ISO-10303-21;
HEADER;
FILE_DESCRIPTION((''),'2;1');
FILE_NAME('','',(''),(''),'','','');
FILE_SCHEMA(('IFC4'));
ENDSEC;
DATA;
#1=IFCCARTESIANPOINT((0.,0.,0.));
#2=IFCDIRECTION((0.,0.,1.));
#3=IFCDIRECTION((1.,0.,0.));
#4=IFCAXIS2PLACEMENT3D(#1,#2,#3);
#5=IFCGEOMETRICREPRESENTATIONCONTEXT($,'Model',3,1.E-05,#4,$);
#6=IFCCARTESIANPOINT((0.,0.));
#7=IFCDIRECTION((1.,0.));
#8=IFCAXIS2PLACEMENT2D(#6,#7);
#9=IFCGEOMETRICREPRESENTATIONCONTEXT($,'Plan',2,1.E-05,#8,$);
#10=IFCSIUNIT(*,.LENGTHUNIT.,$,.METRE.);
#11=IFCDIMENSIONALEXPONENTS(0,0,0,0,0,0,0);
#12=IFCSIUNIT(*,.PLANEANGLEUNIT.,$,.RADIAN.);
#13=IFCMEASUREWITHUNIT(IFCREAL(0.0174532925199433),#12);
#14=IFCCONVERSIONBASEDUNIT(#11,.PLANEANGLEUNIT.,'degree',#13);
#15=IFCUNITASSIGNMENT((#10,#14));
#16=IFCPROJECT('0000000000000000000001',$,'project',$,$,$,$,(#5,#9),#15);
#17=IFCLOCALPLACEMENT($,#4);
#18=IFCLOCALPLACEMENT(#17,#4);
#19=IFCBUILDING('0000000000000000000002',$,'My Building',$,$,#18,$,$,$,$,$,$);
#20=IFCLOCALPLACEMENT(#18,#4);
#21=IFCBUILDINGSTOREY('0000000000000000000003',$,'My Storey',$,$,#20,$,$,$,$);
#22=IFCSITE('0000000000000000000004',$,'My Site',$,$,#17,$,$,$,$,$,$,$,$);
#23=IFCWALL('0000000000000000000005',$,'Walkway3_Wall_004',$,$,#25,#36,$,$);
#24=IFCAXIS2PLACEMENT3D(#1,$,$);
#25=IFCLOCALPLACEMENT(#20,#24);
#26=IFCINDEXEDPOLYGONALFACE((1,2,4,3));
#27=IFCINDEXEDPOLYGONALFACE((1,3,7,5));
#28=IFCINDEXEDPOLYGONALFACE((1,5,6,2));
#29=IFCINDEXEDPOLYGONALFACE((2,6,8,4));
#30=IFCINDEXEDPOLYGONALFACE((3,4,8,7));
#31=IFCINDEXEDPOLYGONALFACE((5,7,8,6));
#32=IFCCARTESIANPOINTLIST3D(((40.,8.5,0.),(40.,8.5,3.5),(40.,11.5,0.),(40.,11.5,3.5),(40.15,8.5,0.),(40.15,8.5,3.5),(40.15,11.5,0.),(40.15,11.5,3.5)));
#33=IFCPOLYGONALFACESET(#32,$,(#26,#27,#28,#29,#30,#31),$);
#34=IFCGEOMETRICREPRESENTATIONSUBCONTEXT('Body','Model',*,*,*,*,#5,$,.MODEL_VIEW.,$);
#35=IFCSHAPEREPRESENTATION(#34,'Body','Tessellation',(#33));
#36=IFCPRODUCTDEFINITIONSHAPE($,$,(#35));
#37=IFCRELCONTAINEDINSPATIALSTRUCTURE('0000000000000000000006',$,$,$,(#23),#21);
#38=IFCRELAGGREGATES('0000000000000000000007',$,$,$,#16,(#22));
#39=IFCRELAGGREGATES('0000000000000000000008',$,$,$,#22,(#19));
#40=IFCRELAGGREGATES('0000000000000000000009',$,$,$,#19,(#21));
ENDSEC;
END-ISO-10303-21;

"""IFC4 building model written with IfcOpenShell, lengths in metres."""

from ifc_helpers import new_model, entity, si_unit, converted_unit, frame, origin_with_axes, origin_2d_with_axis, place, context, subcontext, project, spatial, indexed_curve, outline, extrude, element, save


model = new_model("IFC4")

# Units and contexts
model_context = context("Model", 3, precision=1e-05, world=origin_with_axes())
plan_context = context("Plan", 2, precision=1e-05, world=origin_2d_with_axis())
body_context = subcontext(model_context, "Body", "Model", "MODEL_VIEW")
ifc_project = project(units=[si_unit("LENGTHUNIT", "METRE"), converted_unit("PLANEANGLEUNIT", "degree", entity("IfcReal", 0.0174532925199433), si_unit("PLANEANGLEUNIT", "RADIAN"), dimensions=[0, 0, 0, 0, 0, 0, 0])], contexts=[model_context, plan_context])

# Site, building, storey
site_placement = place(None, origin_with_axes())
site = spatial("IfcSite", under=ifc_project, at=site_placement, Name="My Site")
building_placement = place(site_placement, origin_with_axes())
building = spatial("IfcBuilding", under=site, at=building_placement, Name="My Building")
storey_placement = place(building_placement, origin_with_axes())
storey = spatial("IfcBuildingStorey", under=building, at=storey_placement, Name="My Storey")

# Wall
wall_1_placement = place(storey_placement, frame((40.0, 11.5, 0.0), z_axis=(0.0, 0.0, 1.0), x_axis=(0.0, -1.0, 0.0)))
element("IfcWall", 1, at=wall_1_placement, inside=storey, Name="Walkway3_Wall_004", context=body_context, shape_type="SweptSolid", body=[
    extrude(outline(indexed_curve([(0.0, 0.0), (0.0, 0.15), (3.0, 0.15), (3.0, 0.0), (0.0, 0.0)], self_intersect=False)), origin_with_axes(), (0.0, 0.0, 1.0), 3.5),
])

save(model, "model.ifc")
